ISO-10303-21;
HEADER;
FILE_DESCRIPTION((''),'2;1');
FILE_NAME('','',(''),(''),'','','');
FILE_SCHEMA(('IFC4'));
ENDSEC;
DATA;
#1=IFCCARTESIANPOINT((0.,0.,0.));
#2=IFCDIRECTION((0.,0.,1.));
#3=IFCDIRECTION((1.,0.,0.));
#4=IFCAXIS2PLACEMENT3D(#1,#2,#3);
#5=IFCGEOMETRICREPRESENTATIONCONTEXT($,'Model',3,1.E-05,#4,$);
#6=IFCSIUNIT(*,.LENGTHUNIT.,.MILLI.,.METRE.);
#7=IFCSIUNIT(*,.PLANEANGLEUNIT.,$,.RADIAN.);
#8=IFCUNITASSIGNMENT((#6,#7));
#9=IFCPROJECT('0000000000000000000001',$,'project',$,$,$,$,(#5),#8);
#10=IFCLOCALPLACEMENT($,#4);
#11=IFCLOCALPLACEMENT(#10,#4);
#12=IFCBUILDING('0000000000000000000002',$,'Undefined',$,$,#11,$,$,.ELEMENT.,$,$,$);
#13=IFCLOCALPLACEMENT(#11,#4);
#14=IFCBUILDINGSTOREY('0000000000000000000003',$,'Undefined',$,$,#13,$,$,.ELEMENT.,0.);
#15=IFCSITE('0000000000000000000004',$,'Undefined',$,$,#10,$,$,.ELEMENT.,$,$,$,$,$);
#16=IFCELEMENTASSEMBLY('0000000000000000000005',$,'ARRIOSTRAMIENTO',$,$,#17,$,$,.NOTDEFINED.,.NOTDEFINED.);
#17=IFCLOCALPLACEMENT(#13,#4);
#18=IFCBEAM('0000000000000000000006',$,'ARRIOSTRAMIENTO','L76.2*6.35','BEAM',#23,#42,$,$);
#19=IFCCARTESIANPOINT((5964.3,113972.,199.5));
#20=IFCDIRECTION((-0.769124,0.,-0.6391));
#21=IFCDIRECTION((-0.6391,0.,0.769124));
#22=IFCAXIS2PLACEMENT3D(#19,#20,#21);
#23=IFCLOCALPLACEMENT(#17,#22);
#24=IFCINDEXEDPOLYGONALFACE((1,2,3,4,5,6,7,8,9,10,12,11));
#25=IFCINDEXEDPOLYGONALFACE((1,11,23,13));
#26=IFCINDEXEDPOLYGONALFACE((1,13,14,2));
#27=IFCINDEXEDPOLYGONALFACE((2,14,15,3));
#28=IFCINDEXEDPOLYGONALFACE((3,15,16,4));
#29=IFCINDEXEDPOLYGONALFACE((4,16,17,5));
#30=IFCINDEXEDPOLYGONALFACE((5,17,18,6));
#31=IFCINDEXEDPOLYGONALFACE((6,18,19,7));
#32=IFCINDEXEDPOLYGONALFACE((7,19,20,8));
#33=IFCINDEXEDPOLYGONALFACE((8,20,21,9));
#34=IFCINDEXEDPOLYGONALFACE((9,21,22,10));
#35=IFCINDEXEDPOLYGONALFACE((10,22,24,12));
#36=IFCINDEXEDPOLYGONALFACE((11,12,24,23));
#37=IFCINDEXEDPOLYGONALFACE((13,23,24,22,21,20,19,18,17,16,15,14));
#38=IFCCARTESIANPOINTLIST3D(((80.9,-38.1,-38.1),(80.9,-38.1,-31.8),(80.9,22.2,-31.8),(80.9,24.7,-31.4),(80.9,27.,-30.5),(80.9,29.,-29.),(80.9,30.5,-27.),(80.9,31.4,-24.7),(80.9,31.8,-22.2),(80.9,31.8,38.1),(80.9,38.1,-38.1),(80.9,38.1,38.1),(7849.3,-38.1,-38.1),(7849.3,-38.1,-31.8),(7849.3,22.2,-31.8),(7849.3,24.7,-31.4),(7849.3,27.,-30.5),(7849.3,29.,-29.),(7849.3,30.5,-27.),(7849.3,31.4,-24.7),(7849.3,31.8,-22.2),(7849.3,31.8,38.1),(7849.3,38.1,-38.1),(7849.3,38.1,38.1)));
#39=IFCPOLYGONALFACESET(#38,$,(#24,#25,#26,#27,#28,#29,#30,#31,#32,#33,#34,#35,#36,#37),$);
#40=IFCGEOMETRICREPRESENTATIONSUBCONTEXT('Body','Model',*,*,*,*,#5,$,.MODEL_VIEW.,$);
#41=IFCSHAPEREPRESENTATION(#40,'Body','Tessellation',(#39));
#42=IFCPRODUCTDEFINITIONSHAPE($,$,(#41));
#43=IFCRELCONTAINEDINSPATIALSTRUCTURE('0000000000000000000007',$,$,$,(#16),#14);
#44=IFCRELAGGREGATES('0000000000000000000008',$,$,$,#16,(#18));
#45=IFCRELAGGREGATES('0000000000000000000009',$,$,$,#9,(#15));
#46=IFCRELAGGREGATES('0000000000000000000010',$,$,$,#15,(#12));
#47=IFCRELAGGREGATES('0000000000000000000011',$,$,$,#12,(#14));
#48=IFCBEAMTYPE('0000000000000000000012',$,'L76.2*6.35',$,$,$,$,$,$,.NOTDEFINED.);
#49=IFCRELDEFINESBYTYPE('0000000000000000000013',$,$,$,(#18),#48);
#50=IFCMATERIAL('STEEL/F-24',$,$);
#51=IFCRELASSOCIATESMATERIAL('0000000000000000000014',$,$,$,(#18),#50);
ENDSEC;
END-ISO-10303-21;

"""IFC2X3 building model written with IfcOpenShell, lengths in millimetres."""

from ifc_helpers import new_model, si_unit, frame, origin_with_axes, origin_2d_with_axis, place, context, subcontext, project, spatial, l_section, extrude, clip, halfspace, material, type_object, element, aggregate, save


model = new_model("IFC2X3")

# Units and contexts
model_context = context("Model", 3, precision=1e-05, world=origin_with_axes())
body_context = subcontext(model_context, "Body", "Model", "MODEL_VIEW")
ifc_project = project(units=[si_unit("LENGTHUNIT", "METRE", prefix="MILLI"), si_unit("PLANEANGLEUNIT", "RADIAN")], contexts=[model_context])

# Site, building, storey
site_placement = place(None, origin_with_axes())
site = spatial("IfcSite", under=ifc_project, at=site_placement, Name="Undefined", CompositionType="ELEMENT")
building_placement = place(site_placement, origin_with_axes())
building = spatial("IfcBuilding", under=site, at=building_placement, Name="Undefined", CompositionType="ELEMENT")
storey_placement = place(building_placement, origin_with_axes())
storey = spatial("IfcBuildingStorey", under=building, at=storey_placement, Name="Undefined", CompositionType="ELEMENT", Elevation=0.0)

# Element assembly, beam
assembly_1_placement = place(storey_placement, origin_with_axes())
assembly_1 = element("IfcElementAssembly", 1, at=assembly_1_placement, inside=storey, Name="ARRIOSTRAMIENTO", AssemblyPlace="NOTDEFINED", PredefinedType="NOTDEFINED")
ifc_material_1 = material(Name="STEEL/F-24")
beam_type_1 = type_object("IfcBeamType", Name="L76.2*6.35", PredefinedType="NOTDEFINED")
beam_1_placement = place(assembly_1_placement, frame((5964.3, 113972.0, 199.5), z_axis=(-0.769124, 0.0, -0.6391), x_axis=(-0.6391, 0.0, 0.769124)))
beam_1 = element("IfcBeam", 2, at=beam_1_placement, type_object=beam_type_1, material=ifc_material_1, Name="ARRIOSTRAMIENTO", Description="L76.2*6.35", ObjectType="BEAM", context=body_context, shape_type="Clipping", body=[
    clip(clip(extrude(l_section(Depth=76.2, Width=76.2, Thickness=6.3, FilletRadius=9.5, at=origin_2d_with_axis()), frame((8230.8, 0.0, 0.0), z_axis=(-1.0, 0.0, 0.0), x_axis=(0.0, -1.0, 0.0)), (0.0, 0.0, 1.0), 8230.8), halfspace(frame((7849.3, 38.1, 0.0), z_axis=(-1.0, 0.0, 0.0), x_axis=(0.0, 0.0, -1.0)), True)), halfspace(frame((80.9, 38.1, 0.0), z_axis=(1.0, 0.0, 0.0), x_axis=(0.0, 0.0, 1.0)), True)),
])
aggregate(assembly_1, [beam_1])

save(model, "model.ifc")
